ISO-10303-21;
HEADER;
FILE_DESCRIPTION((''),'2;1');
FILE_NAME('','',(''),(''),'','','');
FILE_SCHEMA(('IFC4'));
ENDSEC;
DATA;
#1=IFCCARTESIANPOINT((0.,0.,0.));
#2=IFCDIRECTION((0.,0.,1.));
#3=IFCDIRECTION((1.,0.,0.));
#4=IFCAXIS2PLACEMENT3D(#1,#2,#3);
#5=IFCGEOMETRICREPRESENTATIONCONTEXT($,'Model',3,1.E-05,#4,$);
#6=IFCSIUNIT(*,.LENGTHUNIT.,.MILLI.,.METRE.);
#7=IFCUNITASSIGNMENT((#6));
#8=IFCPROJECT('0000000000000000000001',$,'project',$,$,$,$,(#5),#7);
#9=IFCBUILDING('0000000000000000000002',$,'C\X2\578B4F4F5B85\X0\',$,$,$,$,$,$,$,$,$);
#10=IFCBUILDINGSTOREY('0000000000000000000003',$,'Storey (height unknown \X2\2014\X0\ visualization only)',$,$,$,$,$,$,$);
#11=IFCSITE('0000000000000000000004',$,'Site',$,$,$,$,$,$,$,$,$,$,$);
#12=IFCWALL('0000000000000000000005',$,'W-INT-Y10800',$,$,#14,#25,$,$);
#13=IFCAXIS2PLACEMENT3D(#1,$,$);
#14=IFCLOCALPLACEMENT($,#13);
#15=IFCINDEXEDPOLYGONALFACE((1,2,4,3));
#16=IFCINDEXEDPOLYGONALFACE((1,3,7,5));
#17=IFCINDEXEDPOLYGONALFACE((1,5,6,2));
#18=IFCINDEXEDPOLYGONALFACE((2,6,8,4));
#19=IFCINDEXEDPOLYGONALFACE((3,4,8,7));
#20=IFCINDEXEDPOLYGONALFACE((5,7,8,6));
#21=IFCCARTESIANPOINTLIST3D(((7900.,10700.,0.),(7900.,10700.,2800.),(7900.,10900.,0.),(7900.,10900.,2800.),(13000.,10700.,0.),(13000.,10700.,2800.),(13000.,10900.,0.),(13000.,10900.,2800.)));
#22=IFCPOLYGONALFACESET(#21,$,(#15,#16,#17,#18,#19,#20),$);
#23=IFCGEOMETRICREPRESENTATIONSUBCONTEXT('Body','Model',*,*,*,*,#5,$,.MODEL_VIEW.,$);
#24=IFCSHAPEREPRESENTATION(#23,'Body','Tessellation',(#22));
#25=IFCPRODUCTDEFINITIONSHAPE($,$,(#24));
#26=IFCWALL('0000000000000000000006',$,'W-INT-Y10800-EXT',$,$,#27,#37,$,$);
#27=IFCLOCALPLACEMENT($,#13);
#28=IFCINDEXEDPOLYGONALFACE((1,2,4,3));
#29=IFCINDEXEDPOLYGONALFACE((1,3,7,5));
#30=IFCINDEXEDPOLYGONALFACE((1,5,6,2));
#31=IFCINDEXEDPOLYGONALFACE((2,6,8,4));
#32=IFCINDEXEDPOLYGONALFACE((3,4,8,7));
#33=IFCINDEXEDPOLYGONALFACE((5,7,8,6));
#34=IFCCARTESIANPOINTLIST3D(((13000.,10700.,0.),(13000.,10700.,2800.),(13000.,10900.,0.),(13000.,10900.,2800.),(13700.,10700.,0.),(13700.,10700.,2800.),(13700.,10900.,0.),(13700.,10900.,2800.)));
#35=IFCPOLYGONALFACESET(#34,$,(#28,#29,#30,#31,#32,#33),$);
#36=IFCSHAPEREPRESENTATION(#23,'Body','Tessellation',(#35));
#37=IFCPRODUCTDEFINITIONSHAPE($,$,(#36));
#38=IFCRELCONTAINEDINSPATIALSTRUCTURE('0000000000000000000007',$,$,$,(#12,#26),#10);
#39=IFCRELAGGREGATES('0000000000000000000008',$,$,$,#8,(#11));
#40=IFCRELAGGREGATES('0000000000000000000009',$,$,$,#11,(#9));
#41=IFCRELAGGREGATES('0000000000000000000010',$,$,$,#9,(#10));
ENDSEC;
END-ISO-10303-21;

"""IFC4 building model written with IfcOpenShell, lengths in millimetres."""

from ifc_helpers import new_model, si_unit, frame, frame_2d, origin_with_axes, place, context, subcontext, project, spatial, rectangle, extrude, element, save


model = new_model("IFC4")

# Units and contexts
model_context = context("Model", 3, precision=1e-05, world=origin_with_axes())
body_context = subcontext(model_context, "Body", "Model", "MODEL_VIEW")
ifc_project = project(units=[si_unit("LENGTHUNIT", "METRE", prefix="MILLI")], contexts=[model_context])

# Site, building, storey
site = spatial("IfcSite", under=ifc_project, Name="Site")
building = spatial("IfcBuilding", under=site, Name="C型住宅")
storey = spatial("IfcBuildingStorey", under=building, Name="Storey (height unknown — visualization only)")

# Walls
wall_1_placement = place(None, frame((7900.0, 10700.0, 0.0), z_axis=(0.0, 0.0, 1.0), x_axis=(1.0, 0.0, 0.0)))
element("IfcWall", 1, at=wall_1_placement, inside=storey, Name="W-INT-Y10800", context=body_context, shape_type="SweptSolid", body=[
    extrude(rectangle(XDim=5100.0, YDim=200.0, at=frame_2d((2550.0, 100.0))), origin_with_axes(), (0.0, 0.0, 1.0), 2800.0),
])
wall_2_placement = place(None, frame((13000.0, 10700.0, 0.0), z_axis=(0.0, 0.0, 1.0), x_axis=(1.0, 0.0, 0.0)))
element("IfcWall", 2, at=wall_2_placement, inside=storey, Name="W-INT-Y10800-EXT", context=body_context, shape_type="SweptSolid", body=[
    extrude(rectangle(XDim=700.0, YDim=200.0, at=frame_2d((350.0, 100.0))), origin_with_axes(), (0.0, 0.0, 1.0), 2800.0),
])

save(model, "model.ifc")
